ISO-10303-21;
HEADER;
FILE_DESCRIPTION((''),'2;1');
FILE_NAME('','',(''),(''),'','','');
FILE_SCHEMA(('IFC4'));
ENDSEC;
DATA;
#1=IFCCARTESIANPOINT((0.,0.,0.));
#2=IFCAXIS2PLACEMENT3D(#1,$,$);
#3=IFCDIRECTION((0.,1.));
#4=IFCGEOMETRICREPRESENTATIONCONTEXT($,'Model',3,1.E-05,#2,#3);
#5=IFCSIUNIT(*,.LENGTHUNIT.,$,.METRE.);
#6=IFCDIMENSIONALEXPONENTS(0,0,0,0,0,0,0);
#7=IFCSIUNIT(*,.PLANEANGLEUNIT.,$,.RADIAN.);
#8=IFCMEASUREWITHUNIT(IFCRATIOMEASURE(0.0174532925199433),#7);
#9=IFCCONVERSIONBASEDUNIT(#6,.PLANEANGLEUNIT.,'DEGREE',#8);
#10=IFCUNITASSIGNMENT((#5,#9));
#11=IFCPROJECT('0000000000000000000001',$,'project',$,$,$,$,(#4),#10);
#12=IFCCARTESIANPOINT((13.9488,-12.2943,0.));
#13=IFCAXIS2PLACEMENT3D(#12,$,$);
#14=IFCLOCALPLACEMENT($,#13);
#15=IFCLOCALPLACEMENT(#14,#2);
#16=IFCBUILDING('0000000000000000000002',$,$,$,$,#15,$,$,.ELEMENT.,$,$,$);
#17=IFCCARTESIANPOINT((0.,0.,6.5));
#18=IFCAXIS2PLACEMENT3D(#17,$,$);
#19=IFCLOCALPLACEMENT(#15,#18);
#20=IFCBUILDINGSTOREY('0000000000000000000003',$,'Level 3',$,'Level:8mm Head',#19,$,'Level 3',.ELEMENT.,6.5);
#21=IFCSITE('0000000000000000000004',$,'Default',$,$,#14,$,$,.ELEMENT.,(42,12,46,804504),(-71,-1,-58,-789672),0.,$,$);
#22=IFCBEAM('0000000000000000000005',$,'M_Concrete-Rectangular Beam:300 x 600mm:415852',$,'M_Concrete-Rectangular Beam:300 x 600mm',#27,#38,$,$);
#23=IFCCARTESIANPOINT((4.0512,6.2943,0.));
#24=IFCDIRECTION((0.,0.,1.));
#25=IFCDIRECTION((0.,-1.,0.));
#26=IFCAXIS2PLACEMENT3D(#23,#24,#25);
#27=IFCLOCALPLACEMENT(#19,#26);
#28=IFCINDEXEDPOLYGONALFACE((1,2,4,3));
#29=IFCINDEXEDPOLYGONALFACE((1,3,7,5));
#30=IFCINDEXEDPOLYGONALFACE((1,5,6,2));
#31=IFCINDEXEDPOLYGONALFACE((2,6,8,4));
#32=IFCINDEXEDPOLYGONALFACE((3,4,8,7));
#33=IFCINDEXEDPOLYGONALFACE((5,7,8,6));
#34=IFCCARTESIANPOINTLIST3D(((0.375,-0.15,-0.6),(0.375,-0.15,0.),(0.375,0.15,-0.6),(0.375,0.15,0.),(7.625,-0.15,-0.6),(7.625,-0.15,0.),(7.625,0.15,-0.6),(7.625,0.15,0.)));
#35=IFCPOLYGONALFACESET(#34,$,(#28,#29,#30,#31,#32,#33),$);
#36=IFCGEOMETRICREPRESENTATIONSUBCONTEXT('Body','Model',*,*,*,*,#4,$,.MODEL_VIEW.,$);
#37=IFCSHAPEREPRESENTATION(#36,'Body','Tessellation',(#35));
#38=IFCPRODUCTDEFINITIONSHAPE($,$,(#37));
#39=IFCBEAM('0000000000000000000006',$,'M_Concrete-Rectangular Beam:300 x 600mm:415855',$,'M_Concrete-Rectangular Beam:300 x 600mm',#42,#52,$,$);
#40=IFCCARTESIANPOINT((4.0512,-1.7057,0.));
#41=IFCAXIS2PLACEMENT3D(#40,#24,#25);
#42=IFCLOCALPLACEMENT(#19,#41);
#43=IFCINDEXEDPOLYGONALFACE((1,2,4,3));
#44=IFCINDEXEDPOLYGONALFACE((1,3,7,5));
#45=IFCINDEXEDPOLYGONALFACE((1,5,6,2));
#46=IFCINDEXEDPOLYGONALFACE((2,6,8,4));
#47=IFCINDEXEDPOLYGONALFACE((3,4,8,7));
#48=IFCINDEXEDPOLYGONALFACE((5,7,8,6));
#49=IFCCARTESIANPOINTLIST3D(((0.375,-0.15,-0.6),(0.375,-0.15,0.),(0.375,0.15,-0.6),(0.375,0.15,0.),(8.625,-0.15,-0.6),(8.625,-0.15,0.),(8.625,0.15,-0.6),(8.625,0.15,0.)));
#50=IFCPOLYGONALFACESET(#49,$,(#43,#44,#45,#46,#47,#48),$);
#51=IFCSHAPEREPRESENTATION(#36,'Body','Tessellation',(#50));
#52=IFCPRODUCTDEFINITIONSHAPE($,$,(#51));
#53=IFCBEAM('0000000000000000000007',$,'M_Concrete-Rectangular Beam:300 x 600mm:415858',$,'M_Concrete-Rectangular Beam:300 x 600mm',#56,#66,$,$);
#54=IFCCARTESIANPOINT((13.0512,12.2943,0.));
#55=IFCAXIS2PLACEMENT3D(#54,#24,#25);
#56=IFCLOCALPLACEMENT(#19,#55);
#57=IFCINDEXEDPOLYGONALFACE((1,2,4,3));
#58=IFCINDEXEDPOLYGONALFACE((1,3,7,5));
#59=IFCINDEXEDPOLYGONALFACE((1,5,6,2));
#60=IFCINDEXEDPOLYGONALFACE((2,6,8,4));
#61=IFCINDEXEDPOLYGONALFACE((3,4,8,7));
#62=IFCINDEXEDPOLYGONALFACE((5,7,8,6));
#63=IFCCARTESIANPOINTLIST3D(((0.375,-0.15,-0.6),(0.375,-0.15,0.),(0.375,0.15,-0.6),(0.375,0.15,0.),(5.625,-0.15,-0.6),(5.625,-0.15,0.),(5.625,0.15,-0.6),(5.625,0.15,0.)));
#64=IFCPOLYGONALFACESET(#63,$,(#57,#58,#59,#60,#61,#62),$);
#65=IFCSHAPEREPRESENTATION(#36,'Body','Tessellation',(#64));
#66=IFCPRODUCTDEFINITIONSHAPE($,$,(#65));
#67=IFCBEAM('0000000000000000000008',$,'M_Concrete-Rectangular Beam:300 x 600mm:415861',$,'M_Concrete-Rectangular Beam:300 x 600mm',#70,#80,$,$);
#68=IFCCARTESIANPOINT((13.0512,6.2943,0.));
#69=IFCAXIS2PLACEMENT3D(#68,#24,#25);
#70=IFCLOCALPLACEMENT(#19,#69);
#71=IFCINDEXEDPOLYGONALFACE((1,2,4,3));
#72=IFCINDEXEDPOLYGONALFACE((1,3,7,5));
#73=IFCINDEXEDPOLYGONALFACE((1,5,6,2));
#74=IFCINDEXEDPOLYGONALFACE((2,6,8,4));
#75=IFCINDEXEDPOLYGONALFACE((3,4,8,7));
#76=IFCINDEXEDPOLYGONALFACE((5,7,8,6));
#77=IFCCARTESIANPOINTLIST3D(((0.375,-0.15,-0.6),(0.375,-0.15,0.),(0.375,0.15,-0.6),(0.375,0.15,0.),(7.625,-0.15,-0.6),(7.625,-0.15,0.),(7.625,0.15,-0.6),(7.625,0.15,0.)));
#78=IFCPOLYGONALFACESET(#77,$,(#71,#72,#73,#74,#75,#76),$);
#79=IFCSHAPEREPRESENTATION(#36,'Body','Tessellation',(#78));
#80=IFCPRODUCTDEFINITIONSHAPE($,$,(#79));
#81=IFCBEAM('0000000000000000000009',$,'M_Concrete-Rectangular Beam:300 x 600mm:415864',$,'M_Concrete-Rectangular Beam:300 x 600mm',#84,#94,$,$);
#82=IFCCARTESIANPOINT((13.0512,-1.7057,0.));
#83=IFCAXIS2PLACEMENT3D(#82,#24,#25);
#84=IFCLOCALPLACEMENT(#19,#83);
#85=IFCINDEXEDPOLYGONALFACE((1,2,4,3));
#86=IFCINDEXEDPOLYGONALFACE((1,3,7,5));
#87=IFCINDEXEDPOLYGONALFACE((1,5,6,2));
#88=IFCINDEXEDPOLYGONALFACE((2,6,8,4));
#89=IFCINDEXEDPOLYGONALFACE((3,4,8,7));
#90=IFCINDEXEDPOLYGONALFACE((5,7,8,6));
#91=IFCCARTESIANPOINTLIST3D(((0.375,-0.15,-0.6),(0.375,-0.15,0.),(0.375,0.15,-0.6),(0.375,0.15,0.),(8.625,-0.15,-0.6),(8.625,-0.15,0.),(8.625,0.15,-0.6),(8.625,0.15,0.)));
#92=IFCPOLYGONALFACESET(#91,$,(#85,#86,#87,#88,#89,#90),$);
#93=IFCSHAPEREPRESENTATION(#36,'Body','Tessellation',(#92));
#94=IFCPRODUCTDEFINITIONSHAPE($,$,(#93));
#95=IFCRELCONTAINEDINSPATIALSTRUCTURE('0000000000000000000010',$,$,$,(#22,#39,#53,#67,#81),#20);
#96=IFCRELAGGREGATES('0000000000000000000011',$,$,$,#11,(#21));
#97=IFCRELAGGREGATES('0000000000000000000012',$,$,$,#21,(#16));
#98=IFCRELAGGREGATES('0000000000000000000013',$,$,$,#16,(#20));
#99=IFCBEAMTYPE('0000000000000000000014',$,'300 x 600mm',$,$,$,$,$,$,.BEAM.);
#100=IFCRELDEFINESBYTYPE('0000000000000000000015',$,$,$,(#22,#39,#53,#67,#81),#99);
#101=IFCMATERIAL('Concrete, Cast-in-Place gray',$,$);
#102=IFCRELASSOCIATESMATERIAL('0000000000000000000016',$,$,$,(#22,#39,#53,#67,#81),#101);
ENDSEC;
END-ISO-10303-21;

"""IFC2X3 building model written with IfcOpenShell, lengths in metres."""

from ifc_helpers import new_model, entity, si_unit, converted_unit, direction, frame, frame_2d, origin, origin_2d_with_axis, place, context, subcontext, project, spatial, rectangle, extrude, material, type_object, element, save


model = new_model("IFC2X3")

# Units and contexts
model_context = context("Model", 3, precision=1e-05, world=origin(), true_north=direction((0.0, 1.0)))
body_context = subcontext(model_context, "Body", "Model", "MODEL_VIEW")
ifc_project = project(units=[si_unit("LENGTHUNIT", "METRE"), converted_unit("PLANEANGLEUNIT", "DEGREE", entity("IfcRatioMeasure", 0.0174532925199433), si_unit("PLANEANGLEUNIT", "RADIAN"), dimensions=[0, 0, 0, 0, 0, 0, 0])], contexts=[model_context])

# Site, building, storey
site_placement = place(None, frame((13.9488, -12.2943, 0.0)))
site = spatial("IfcSite", under=ifc_project, at=site_placement, Name="Default", CompositionType="ELEMENT", RefLatitude=(42, 12, 46, 804504), RefLongitude=(-71, -1, -58, -789672), RefElevation=0.0)
building_placement = place(site_placement, origin())
building = spatial("IfcBuilding", under=site, at=building_placement, CompositionType="ELEMENT")
storey_placement = place(building_placement, frame((0.0, 0.0, 6.5)))
storey = spatial("IfcBuildingStorey", under=building, at=storey_placement, Name="Level 3", ObjectType="Level:8mm Head", LongName="Level 3", CompositionType="ELEMENT", Elevation=6.5)

# Shared definitions
ifc_material = material(Name="Concrete, Cast-in-Place gray")

# Beams
beam_type_1 = type_object("IfcBeamType", Name="300 x 600mm", PredefinedType="BEAM")
beam_1_placement = place(storey_placement, frame((4.0512, 6.2943, 0.0), z_axis=(0.0, 0.0, 1.0), x_axis=(0.0, -1.0, 0.0)))
element("IfcBeam", 1, at=beam_1_placement, inside=storey, type_object=beam_type_1, material=ifc_material, Name="M_Concrete-Rectangular Beam:300 x 600mm:415852", ObjectType="M_Concrete-Rectangular Beam:300 x 600mm", context=body_context, shape_type="SweptSolid", body=[
    extrude(rectangle(XDim=0.6, YDim=0.3, at=frame_2d((0.0, 0.0), x_axis=(1.0, 0.0))), frame((0.375, 0.0, -0.3), z_axis=(1.0, 0.0, 0.0), x_axis=(0.0, 0.0, -1.0)), (0.0, 0.0, 1.0), 7.25),
])
beam_2_placement = place(storey_placement, frame((4.0512, -1.7057, 0.0), z_axis=(0.0, 0.0, 1.0), x_axis=(0.0, -1.0, 0.0)))
element("IfcBeam", 2, at=beam_2_placement, inside=storey, type_object=beam_type_1, material=ifc_material, Name="M_Concrete-Rectangular Beam:300 x 600mm:415855", ObjectType="M_Concrete-Rectangular Beam:300 x 600mm", context=body_context, shape_type="SweptSolid", body=[
    extrude(rectangle(XDim=0.6, YDim=0.3, at=frame_2d((0.0, 0.0), x_axis=(1.0, 0.0))), frame((0.375, 0.0, -0.3), z_axis=(1.0, 0.0, 0.0), x_axis=(0.0, 0.0, -1.0)), (0.0, 0.0, 1.0), 8.25),
])
beam_3_placement = place(storey_placement, frame((13.0512, 12.2943, 0.0), z_axis=(0.0, 0.0, 1.0), x_axis=(0.0, -1.0, 0.0)))
element("IfcBeam", 3, at=beam_3_placement, inside=storey, type_object=beam_type_1, material=ifc_material, Name="M_Concrete-Rectangular Beam:300 x 600mm:415858", ObjectType="M_Concrete-Rectangular Beam:300 x 600mm", context=body_context, shape_type="SweptSolid", body=[
    extrude(rectangle(XDim=0.6, YDim=0.3, at=origin_2d_with_axis()), frame((0.375, 0.0, -0.3), z_axis=(1.0, 0.0, 0.0), x_axis=(0.0, 0.0, -1.0)), (0.0, 0.0, 1.0), 5.25),
])
beam_4_placement = place(storey_placement, frame((13.0512, 6.2943, 0.0), z_axis=(0.0, 0.0, 1.0), x_axis=(0.0, -1.0, 0.0)))
element("IfcBeam", 4, at=beam_4_placement, inside=storey, type_object=beam_type_1, material=ifc_material, Name="M_Concrete-Rectangular Beam:300 x 600mm:415861", ObjectType="M_Concrete-Rectangular Beam:300 x 600mm", context=body_context, shape_type="SweptSolid", body=[
    extrude(rectangle(XDim=0.6, YDim=0.3, at=frame_2d((0.0, 0.0), x_axis=(1.0, 0.0))), frame((0.375, 0.0, -0.3), z_axis=(1.0, 0.0, 0.0), x_axis=(0.0, 0.0, -1.0)), (0.0, 0.0, 1.0), 7.25),
])
beam_5_placement = place(storey_placement, frame((13.0512, -1.7057, 0.0), z_axis=(0.0, 0.0, 1.0), x_axis=(0.0, -1.0, 0.0)))
element("IfcBeam", 5, at=beam_5_placement, inside=storey, type_object=beam_type_1, material=ifc_material, Name="M_Concrete-Rectangular Beam:300 x 600mm:415864", ObjectType="M_Concrete-Rectangular Beam:300 x 600mm", context=body_context, shape_type="SweptSolid", body=[
    extrude(rectangle(XDim=0.6, YDim=0.3, at=frame_2d((0.0, 0.0), x_axis=(1.0, 0.0))), frame((0.375, 0.0, -0.3), z_axis=(1.0, 0.0, 0.0), x_axis=(0.0, 0.0, -1.0)), (0.0, 0.0, 1.0), 8.25),
])

save(model, "model.ifc")
